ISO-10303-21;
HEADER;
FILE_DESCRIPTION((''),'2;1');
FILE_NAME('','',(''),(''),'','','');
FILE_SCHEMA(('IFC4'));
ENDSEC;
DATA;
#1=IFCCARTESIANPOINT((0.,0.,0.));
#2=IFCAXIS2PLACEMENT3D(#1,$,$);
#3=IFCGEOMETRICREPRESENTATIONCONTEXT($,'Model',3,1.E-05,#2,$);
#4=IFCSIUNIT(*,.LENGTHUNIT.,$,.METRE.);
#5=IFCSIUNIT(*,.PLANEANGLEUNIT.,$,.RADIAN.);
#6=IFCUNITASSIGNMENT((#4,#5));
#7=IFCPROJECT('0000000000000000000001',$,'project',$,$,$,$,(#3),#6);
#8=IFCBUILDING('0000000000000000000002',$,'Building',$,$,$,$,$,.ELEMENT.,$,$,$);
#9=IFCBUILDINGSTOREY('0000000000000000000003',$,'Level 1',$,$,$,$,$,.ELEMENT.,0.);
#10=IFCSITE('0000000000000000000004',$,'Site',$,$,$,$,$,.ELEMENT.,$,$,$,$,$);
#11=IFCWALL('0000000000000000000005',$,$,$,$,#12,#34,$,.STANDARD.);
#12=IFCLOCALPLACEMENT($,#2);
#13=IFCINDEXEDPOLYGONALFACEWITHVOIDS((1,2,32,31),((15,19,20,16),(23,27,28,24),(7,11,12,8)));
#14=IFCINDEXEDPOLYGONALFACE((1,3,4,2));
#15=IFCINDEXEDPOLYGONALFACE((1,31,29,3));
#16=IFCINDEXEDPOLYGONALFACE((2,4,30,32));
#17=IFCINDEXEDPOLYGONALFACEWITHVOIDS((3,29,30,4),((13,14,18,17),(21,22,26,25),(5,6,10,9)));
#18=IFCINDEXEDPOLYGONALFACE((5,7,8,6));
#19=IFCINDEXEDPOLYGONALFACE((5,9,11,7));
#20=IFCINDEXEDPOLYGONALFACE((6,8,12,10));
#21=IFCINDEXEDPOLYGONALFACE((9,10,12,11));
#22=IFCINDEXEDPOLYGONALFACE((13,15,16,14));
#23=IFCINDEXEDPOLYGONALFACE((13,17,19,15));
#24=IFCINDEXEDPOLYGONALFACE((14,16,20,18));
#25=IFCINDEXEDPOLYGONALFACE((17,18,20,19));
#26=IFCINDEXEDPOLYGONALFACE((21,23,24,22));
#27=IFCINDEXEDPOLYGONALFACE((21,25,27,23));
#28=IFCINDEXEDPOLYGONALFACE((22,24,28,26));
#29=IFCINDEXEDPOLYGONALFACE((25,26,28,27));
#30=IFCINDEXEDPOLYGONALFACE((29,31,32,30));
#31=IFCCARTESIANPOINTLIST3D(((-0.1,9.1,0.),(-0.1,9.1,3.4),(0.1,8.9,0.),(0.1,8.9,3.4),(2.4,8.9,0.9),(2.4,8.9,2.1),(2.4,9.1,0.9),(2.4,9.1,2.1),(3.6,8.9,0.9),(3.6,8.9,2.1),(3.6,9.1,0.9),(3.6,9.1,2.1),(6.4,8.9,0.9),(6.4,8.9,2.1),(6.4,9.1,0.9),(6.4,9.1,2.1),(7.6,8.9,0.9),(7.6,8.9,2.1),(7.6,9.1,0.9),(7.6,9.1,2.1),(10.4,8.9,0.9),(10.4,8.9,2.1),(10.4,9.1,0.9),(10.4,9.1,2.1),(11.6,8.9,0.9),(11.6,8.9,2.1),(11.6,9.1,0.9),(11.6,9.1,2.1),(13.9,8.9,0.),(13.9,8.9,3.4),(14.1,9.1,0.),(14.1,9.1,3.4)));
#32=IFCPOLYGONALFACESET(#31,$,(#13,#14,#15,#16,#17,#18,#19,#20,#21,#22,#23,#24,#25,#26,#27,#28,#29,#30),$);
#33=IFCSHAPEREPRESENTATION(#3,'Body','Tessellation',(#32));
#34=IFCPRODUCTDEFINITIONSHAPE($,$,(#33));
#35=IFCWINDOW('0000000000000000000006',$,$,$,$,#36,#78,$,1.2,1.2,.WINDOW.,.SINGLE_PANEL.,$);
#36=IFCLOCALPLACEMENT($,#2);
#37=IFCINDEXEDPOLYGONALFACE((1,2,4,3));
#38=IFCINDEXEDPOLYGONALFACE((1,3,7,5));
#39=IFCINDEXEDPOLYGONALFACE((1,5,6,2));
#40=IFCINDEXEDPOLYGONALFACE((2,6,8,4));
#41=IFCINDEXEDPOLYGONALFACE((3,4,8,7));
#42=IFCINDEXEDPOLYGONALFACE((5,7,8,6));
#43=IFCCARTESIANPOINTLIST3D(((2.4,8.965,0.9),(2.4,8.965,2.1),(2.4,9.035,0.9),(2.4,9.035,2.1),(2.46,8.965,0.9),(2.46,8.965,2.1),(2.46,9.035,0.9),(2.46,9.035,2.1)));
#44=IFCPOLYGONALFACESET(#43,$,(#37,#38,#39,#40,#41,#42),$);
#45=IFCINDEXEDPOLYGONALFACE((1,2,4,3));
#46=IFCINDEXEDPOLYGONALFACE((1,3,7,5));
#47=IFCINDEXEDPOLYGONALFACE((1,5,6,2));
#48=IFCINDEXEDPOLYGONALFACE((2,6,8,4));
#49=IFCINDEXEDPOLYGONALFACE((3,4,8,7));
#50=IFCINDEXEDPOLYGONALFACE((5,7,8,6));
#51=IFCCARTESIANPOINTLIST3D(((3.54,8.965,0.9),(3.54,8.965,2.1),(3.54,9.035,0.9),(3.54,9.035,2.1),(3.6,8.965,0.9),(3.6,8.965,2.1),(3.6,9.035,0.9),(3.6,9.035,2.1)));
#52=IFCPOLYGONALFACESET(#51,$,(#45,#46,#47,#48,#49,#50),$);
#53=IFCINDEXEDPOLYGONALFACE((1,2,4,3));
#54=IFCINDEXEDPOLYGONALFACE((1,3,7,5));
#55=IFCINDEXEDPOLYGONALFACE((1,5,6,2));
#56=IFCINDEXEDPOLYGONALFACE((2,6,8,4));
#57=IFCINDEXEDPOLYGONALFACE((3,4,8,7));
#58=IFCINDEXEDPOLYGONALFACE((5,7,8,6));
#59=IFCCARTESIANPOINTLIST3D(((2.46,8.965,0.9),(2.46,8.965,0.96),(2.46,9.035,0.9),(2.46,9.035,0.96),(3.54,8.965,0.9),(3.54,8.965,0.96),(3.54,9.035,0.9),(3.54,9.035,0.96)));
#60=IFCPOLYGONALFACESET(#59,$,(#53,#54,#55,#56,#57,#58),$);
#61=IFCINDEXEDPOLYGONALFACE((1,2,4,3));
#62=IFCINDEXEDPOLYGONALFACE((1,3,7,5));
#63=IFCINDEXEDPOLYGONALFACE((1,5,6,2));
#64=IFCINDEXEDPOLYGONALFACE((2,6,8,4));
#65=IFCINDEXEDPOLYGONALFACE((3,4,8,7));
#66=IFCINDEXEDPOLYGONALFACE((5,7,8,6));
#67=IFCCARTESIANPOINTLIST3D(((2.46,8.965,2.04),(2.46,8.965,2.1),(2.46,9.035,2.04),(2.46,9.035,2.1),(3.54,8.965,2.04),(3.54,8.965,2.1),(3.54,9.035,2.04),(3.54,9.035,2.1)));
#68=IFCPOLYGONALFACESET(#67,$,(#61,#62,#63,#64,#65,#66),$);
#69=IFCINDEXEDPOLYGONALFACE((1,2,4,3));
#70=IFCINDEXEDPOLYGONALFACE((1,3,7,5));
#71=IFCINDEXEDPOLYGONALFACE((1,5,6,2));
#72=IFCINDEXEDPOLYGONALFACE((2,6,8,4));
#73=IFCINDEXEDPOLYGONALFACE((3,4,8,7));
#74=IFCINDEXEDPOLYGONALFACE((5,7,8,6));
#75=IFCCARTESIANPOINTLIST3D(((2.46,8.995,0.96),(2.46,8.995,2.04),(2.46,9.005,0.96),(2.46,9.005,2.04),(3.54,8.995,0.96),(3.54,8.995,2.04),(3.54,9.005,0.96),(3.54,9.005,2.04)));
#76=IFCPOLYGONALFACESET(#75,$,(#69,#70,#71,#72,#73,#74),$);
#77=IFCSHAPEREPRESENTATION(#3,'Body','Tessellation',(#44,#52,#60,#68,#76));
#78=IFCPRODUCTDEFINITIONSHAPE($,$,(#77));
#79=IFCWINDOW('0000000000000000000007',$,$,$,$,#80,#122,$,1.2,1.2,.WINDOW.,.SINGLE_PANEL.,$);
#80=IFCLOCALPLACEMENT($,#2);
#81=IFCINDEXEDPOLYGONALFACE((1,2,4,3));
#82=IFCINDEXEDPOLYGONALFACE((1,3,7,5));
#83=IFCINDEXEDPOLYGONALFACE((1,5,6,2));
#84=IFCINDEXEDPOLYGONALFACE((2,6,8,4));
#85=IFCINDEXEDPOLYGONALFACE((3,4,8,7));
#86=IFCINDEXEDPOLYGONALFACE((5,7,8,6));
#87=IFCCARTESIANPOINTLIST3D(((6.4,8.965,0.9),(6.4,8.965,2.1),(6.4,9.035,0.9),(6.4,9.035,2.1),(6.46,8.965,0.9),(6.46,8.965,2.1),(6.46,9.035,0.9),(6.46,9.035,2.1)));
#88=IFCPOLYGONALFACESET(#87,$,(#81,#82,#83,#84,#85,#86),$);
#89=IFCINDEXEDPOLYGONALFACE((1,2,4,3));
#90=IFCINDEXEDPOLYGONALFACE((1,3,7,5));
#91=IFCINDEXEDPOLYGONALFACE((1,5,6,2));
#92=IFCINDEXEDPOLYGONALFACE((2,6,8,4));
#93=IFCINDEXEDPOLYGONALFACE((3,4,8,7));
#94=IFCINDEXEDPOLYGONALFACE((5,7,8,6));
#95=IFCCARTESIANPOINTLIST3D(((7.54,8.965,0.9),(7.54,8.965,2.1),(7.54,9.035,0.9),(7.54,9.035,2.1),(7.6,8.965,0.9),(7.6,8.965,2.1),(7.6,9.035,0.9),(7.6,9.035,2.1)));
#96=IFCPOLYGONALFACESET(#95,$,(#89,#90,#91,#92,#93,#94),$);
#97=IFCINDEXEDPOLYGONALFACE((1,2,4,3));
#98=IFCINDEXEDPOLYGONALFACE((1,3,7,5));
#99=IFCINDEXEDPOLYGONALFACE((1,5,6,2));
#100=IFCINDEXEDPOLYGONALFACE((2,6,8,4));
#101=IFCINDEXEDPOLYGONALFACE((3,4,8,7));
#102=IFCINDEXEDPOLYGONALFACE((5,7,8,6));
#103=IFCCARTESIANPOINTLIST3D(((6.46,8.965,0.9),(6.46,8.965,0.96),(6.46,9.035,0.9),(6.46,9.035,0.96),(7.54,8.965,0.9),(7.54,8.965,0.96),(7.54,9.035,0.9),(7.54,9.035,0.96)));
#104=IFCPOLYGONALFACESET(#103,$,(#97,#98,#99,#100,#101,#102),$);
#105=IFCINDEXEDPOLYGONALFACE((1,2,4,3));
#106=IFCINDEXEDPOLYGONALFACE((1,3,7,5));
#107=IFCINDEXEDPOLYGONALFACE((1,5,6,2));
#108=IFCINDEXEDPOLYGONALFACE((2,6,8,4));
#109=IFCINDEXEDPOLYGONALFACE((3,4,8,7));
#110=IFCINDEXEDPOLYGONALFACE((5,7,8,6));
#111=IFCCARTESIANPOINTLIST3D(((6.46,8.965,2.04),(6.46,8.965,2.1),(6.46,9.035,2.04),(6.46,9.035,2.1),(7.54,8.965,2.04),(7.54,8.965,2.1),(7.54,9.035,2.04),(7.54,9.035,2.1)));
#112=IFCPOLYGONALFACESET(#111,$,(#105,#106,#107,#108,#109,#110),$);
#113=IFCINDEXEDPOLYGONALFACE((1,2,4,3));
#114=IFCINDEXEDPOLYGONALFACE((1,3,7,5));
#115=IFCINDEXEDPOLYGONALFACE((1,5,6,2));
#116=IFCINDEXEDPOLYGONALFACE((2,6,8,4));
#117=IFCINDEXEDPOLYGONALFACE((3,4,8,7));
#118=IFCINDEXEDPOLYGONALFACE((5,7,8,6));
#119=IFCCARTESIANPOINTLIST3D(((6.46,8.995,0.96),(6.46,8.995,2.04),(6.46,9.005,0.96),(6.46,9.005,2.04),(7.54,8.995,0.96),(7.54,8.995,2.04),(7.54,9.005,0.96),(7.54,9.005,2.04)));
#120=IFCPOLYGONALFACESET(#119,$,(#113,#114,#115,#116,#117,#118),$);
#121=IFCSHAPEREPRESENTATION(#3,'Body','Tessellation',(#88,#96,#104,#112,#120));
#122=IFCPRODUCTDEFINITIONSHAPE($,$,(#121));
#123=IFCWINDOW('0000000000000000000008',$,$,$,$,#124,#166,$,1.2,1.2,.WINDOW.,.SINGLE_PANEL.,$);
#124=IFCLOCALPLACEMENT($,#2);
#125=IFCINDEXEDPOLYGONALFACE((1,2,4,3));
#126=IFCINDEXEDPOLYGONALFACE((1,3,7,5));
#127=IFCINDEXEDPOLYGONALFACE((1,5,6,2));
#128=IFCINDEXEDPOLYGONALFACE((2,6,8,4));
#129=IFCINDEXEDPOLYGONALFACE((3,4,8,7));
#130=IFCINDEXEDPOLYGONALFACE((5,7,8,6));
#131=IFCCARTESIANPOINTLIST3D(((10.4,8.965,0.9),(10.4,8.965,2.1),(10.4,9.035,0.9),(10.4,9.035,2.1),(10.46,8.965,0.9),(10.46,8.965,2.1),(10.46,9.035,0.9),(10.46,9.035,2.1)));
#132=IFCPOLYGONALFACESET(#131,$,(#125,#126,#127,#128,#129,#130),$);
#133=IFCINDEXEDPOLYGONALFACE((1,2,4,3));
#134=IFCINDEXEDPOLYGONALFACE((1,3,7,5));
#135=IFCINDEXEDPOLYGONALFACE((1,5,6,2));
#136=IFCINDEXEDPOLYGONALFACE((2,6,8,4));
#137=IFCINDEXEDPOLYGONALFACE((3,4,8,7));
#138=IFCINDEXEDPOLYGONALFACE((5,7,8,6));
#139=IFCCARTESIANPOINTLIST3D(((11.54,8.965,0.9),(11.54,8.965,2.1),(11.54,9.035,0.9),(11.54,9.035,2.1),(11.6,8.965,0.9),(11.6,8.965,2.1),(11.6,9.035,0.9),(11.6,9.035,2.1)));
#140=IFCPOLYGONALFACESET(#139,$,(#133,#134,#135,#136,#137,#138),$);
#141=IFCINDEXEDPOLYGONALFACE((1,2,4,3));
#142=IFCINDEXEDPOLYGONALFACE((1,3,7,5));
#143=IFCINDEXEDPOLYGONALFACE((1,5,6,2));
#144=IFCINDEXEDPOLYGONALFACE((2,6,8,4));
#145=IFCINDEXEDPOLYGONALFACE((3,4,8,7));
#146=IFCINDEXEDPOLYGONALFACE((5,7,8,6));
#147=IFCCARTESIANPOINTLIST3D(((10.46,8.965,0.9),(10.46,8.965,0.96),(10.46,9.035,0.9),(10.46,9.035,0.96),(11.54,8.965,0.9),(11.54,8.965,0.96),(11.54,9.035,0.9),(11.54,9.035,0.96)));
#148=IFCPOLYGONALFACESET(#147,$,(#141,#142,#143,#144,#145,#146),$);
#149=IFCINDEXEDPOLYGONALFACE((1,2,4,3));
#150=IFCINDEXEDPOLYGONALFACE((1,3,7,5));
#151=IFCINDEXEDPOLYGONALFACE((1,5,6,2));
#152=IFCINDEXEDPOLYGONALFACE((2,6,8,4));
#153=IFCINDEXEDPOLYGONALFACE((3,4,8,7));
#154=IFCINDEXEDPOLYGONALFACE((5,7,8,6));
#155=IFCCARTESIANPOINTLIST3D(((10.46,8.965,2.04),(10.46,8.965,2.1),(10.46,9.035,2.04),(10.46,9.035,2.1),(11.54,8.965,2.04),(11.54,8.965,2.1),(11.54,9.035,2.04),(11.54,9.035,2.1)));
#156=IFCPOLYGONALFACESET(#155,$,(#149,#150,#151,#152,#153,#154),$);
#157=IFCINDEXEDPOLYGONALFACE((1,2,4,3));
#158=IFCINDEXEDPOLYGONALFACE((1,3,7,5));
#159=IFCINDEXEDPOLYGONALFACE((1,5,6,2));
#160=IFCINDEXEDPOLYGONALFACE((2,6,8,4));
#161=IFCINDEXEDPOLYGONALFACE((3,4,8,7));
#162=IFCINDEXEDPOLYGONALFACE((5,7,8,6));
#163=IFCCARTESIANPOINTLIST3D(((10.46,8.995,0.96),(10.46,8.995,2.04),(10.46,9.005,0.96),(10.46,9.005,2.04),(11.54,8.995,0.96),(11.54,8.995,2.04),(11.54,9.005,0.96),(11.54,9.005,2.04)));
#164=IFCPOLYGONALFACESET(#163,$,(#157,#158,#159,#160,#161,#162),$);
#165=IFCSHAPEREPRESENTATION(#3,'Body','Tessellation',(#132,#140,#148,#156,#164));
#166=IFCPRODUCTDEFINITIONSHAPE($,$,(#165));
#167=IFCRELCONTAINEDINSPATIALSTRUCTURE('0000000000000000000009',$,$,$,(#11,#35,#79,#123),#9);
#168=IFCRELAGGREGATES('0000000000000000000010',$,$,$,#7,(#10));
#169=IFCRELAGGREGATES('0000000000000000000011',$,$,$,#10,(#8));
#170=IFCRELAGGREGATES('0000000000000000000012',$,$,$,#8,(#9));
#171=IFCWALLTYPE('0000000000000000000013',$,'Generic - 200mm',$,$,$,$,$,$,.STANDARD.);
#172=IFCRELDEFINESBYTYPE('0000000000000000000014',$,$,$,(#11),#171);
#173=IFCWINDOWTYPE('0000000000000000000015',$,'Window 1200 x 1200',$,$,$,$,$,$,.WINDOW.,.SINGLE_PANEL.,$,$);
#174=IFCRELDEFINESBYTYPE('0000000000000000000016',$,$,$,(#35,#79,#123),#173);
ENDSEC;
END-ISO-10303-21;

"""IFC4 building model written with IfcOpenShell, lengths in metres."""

from ifc_helpers import new_model, si_unit, frame, frame_2d, origin, origin_with_axes, origin_2d, place, context, project, spatial, polyline, rectangle, outline, extrude, type_object, element, fill, save


model = new_model("IFC4")

# Units and contexts
model_context = context("Model", 3, precision=1e-05, world=origin())
ifc_project = project(units=[si_unit("LENGTHUNIT", "METRE"), si_unit("PLANEANGLEUNIT", "RADIAN")], contexts=[model_context])

# Site, building, storey
site = spatial("IfcSite", under=ifc_project, Name="Site", CompositionType="ELEMENT")
building = spatial("IfcBuilding", under=site, Name="Building", CompositionType="ELEMENT")
storey = spatial("IfcBuildingStorey", under=building, Name="Level 1", CompositionType="ELEMENT", Elevation=0.0)

# Shared definitions
wall_type = type_object("IfcWallType", Name="Generic - 200mm", PredefinedType="STANDARD")
window_type = type_object("IfcWindowType", Name="Window 1200 x 1200", PartitioningType="SINGLE_PANEL", PredefinedType="WINDOW")

# Wall, openings, windows
wall_1_placement = place(None, frame((0.0, 9.0, 0.0), z_axis=(0.0, 0.0, 1.0), x_axis=(1.0, 0.0, 0.0)))
wall_1 = element("IfcWall", 1, at=wall_1_placement, inside=storey, type_object=wall_type, PredefinedType="STANDARD", context=model_context, shape_type="SweptSolid", body=[
    extrude(outline(polyline([(0.1, -0.1), (13.9, -0.1), (14.1, 0.1), (-0.1, 0.1), (0.1, -0.1)])), origin(), (0.0, 0.0, 1.0), 3.4),
])
opening_1_placement = place(wall_1_placement, frame((3.0, 0.0, 0.9), z_axis=(0.0, 0.0, 1.0), x_axis=(1.0, 0.0, 0.0)))
opening_1 = element("IfcOpeningElement", 2, at=opening_1_placement, cuts=wall_1, PredefinedType="OPENING", context=model_context, shape_type="SweptSolid", body=[
    extrude(rectangle(XDim=1.2, YDim=0.202, at=origin_2d()), origin(), (0.0, 0.0, 1.0), 1.2),
])
opening_2_placement = place(wall_1_placement, frame((7.0, 0.0, 0.9), z_axis=(0.0, 0.0, 1.0), x_axis=(1.0, 0.0, 0.0)))
opening_2 = element("IfcOpeningElement", 3, at=opening_2_placement, cuts=wall_1, PredefinedType="OPENING", context=model_context, shape_type="SweptSolid", body=[
    extrude(rectangle(XDim=1.2, YDim=0.202, at=origin_2d()), origin(), (0.0, 0.0, 1.0), 1.2),
])
opening_3_placement = place(wall_1_placement, frame((11.0, 0.0, 0.9), z_axis=(0.0, 0.0, 1.0), x_axis=(1.0, 0.0, 0.0)))
opening_3 = element("IfcOpeningElement", 4, at=opening_3_placement, cuts=wall_1, PredefinedType="OPENING", context=model_context, shape_type="SweptSolid", body=[
    extrude(rectangle(XDim=1.2, YDim=0.202, at=origin_2d()), origin(), (0.0, 0.0, 1.0), 1.2),
])
window_1_placement = place(opening_1_placement, origin_with_axes())
window_1 = element("IfcWindow", 5, at=window_1_placement, inside=storey, type_object=window_type, OverallHeight=1.2, OverallWidth=1.2, PartitioningType="SINGLE_PANEL", PredefinedType="WINDOW", context=model_context, shape_type="SweptSolid", body=[
    extrude(rectangle(XDim=0.06, YDim=0.07, at=frame_2d((-0.57, 0.0))), origin(), (0.0, 0.0, 1.0), 1.2),
    extrude(rectangle(XDim=0.06, YDim=0.07, at=frame_2d((0.57, 0.0))), origin(), (0.0, 0.0, 1.0), 1.2),
    extrude(rectangle(XDim=1.08, YDim=0.07, at=origin_2d()), origin(), (0.0, 0.0, 1.0), 0.06),
    extrude(rectangle(XDim=1.08, YDim=0.07, at=origin_2d()), frame((0.0, 0.0, 1.14)), (0.0, 0.0, 1.0), 0.06),
    extrude(rectangle(XDim=1.08, YDim=0.01, at=origin_2d()), frame((0.0, 0.0, 0.06)), (0.0, 0.0, 1.0), 1.08),
])
fill(opening_1, window_1)
window_2_placement = place(opening_2_placement, origin_with_axes())
window_2 = element("IfcWindow", 6, at=window_2_placement, inside=storey, type_object=window_type, OverallHeight=1.2, OverallWidth=1.2, PartitioningType="SINGLE_PANEL", PredefinedType="WINDOW", context=model_context, shape_type="SweptSolid", body=[
    extrude(rectangle(XDim=0.06, YDim=0.07, at=frame_2d((-0.57, 0.0))), origin(), (0.0, 0.0, 1.0), 1.2),
    extrude(rectangle(XDim=0.06, YDim=0.07, at=frame_2d((0.57, 0.0))), origin(), (0.0, 0.0, 1.0), 1.2),
    extrude(rectangle(XDim=1.08, YDim=0.07, at=origin_2d()), origin(), (0.0, 0.0, 1.0), 0.06),
    extrude(rectangle(XDim=1.08, YDim=0.07, at=origin_2d()), frame((0.0, 0.0, 1.14)), (0.0, 0.0, 1.0), 0.06),
    extrude(rectangle(XDim=1.08, YDim=0.01, at=origin_2d()), frame((0.0, 0.0, 0.06)), (0.0, 0.0, 1.0), 1.08),
])
fill(opening_2, window_2)
window_3_placement = place(opening_3_placement, origin_with_axes())
window_3 = element("IfcWindow", 7, at=window_3_placement, inside=storey, type_object=window_type, OverallHeight=1.2, OverallWidth=1.2, PartitioningType="SINGLE_PANEL", PredefinedType="WINDOW", context=model_context, shape_type="SweptSolid", body=[
    extrude(rectangle(XDim=0.06, YDim=0.07, at=frame_2d((-0.57, 0.0))), origin(), (0.0, 0.0, 1.0), 1.2),
    extrude(rectangle(XDim=0.06, YDim=0.07, at=frame_2d((0.57, 0.0))), origin(), (0.0, 0.0, 1.0), 1.2),
    extrude(rectangle(XDim=1.08, YDim=0.07, at=origin_2d()), origin(), (0.0, 0.0, 1.0), 0.06),
    extrude(rectangle(XDim=1.08, YDim=0.07, at=origin_2d()), frame((0.0, 0.0, 1.14)), (0.0, 0.0, 1.0), 0.06),
    extrude(rectangle(XDim=1.08, YDim=0.01, at=origin_2d()), frame((0.0, 0.0, 0.06)), (0.0, 0.0, 1.0), 1.08),
])
fill(opening_3, window_3)

save(model, "model.ifc")
